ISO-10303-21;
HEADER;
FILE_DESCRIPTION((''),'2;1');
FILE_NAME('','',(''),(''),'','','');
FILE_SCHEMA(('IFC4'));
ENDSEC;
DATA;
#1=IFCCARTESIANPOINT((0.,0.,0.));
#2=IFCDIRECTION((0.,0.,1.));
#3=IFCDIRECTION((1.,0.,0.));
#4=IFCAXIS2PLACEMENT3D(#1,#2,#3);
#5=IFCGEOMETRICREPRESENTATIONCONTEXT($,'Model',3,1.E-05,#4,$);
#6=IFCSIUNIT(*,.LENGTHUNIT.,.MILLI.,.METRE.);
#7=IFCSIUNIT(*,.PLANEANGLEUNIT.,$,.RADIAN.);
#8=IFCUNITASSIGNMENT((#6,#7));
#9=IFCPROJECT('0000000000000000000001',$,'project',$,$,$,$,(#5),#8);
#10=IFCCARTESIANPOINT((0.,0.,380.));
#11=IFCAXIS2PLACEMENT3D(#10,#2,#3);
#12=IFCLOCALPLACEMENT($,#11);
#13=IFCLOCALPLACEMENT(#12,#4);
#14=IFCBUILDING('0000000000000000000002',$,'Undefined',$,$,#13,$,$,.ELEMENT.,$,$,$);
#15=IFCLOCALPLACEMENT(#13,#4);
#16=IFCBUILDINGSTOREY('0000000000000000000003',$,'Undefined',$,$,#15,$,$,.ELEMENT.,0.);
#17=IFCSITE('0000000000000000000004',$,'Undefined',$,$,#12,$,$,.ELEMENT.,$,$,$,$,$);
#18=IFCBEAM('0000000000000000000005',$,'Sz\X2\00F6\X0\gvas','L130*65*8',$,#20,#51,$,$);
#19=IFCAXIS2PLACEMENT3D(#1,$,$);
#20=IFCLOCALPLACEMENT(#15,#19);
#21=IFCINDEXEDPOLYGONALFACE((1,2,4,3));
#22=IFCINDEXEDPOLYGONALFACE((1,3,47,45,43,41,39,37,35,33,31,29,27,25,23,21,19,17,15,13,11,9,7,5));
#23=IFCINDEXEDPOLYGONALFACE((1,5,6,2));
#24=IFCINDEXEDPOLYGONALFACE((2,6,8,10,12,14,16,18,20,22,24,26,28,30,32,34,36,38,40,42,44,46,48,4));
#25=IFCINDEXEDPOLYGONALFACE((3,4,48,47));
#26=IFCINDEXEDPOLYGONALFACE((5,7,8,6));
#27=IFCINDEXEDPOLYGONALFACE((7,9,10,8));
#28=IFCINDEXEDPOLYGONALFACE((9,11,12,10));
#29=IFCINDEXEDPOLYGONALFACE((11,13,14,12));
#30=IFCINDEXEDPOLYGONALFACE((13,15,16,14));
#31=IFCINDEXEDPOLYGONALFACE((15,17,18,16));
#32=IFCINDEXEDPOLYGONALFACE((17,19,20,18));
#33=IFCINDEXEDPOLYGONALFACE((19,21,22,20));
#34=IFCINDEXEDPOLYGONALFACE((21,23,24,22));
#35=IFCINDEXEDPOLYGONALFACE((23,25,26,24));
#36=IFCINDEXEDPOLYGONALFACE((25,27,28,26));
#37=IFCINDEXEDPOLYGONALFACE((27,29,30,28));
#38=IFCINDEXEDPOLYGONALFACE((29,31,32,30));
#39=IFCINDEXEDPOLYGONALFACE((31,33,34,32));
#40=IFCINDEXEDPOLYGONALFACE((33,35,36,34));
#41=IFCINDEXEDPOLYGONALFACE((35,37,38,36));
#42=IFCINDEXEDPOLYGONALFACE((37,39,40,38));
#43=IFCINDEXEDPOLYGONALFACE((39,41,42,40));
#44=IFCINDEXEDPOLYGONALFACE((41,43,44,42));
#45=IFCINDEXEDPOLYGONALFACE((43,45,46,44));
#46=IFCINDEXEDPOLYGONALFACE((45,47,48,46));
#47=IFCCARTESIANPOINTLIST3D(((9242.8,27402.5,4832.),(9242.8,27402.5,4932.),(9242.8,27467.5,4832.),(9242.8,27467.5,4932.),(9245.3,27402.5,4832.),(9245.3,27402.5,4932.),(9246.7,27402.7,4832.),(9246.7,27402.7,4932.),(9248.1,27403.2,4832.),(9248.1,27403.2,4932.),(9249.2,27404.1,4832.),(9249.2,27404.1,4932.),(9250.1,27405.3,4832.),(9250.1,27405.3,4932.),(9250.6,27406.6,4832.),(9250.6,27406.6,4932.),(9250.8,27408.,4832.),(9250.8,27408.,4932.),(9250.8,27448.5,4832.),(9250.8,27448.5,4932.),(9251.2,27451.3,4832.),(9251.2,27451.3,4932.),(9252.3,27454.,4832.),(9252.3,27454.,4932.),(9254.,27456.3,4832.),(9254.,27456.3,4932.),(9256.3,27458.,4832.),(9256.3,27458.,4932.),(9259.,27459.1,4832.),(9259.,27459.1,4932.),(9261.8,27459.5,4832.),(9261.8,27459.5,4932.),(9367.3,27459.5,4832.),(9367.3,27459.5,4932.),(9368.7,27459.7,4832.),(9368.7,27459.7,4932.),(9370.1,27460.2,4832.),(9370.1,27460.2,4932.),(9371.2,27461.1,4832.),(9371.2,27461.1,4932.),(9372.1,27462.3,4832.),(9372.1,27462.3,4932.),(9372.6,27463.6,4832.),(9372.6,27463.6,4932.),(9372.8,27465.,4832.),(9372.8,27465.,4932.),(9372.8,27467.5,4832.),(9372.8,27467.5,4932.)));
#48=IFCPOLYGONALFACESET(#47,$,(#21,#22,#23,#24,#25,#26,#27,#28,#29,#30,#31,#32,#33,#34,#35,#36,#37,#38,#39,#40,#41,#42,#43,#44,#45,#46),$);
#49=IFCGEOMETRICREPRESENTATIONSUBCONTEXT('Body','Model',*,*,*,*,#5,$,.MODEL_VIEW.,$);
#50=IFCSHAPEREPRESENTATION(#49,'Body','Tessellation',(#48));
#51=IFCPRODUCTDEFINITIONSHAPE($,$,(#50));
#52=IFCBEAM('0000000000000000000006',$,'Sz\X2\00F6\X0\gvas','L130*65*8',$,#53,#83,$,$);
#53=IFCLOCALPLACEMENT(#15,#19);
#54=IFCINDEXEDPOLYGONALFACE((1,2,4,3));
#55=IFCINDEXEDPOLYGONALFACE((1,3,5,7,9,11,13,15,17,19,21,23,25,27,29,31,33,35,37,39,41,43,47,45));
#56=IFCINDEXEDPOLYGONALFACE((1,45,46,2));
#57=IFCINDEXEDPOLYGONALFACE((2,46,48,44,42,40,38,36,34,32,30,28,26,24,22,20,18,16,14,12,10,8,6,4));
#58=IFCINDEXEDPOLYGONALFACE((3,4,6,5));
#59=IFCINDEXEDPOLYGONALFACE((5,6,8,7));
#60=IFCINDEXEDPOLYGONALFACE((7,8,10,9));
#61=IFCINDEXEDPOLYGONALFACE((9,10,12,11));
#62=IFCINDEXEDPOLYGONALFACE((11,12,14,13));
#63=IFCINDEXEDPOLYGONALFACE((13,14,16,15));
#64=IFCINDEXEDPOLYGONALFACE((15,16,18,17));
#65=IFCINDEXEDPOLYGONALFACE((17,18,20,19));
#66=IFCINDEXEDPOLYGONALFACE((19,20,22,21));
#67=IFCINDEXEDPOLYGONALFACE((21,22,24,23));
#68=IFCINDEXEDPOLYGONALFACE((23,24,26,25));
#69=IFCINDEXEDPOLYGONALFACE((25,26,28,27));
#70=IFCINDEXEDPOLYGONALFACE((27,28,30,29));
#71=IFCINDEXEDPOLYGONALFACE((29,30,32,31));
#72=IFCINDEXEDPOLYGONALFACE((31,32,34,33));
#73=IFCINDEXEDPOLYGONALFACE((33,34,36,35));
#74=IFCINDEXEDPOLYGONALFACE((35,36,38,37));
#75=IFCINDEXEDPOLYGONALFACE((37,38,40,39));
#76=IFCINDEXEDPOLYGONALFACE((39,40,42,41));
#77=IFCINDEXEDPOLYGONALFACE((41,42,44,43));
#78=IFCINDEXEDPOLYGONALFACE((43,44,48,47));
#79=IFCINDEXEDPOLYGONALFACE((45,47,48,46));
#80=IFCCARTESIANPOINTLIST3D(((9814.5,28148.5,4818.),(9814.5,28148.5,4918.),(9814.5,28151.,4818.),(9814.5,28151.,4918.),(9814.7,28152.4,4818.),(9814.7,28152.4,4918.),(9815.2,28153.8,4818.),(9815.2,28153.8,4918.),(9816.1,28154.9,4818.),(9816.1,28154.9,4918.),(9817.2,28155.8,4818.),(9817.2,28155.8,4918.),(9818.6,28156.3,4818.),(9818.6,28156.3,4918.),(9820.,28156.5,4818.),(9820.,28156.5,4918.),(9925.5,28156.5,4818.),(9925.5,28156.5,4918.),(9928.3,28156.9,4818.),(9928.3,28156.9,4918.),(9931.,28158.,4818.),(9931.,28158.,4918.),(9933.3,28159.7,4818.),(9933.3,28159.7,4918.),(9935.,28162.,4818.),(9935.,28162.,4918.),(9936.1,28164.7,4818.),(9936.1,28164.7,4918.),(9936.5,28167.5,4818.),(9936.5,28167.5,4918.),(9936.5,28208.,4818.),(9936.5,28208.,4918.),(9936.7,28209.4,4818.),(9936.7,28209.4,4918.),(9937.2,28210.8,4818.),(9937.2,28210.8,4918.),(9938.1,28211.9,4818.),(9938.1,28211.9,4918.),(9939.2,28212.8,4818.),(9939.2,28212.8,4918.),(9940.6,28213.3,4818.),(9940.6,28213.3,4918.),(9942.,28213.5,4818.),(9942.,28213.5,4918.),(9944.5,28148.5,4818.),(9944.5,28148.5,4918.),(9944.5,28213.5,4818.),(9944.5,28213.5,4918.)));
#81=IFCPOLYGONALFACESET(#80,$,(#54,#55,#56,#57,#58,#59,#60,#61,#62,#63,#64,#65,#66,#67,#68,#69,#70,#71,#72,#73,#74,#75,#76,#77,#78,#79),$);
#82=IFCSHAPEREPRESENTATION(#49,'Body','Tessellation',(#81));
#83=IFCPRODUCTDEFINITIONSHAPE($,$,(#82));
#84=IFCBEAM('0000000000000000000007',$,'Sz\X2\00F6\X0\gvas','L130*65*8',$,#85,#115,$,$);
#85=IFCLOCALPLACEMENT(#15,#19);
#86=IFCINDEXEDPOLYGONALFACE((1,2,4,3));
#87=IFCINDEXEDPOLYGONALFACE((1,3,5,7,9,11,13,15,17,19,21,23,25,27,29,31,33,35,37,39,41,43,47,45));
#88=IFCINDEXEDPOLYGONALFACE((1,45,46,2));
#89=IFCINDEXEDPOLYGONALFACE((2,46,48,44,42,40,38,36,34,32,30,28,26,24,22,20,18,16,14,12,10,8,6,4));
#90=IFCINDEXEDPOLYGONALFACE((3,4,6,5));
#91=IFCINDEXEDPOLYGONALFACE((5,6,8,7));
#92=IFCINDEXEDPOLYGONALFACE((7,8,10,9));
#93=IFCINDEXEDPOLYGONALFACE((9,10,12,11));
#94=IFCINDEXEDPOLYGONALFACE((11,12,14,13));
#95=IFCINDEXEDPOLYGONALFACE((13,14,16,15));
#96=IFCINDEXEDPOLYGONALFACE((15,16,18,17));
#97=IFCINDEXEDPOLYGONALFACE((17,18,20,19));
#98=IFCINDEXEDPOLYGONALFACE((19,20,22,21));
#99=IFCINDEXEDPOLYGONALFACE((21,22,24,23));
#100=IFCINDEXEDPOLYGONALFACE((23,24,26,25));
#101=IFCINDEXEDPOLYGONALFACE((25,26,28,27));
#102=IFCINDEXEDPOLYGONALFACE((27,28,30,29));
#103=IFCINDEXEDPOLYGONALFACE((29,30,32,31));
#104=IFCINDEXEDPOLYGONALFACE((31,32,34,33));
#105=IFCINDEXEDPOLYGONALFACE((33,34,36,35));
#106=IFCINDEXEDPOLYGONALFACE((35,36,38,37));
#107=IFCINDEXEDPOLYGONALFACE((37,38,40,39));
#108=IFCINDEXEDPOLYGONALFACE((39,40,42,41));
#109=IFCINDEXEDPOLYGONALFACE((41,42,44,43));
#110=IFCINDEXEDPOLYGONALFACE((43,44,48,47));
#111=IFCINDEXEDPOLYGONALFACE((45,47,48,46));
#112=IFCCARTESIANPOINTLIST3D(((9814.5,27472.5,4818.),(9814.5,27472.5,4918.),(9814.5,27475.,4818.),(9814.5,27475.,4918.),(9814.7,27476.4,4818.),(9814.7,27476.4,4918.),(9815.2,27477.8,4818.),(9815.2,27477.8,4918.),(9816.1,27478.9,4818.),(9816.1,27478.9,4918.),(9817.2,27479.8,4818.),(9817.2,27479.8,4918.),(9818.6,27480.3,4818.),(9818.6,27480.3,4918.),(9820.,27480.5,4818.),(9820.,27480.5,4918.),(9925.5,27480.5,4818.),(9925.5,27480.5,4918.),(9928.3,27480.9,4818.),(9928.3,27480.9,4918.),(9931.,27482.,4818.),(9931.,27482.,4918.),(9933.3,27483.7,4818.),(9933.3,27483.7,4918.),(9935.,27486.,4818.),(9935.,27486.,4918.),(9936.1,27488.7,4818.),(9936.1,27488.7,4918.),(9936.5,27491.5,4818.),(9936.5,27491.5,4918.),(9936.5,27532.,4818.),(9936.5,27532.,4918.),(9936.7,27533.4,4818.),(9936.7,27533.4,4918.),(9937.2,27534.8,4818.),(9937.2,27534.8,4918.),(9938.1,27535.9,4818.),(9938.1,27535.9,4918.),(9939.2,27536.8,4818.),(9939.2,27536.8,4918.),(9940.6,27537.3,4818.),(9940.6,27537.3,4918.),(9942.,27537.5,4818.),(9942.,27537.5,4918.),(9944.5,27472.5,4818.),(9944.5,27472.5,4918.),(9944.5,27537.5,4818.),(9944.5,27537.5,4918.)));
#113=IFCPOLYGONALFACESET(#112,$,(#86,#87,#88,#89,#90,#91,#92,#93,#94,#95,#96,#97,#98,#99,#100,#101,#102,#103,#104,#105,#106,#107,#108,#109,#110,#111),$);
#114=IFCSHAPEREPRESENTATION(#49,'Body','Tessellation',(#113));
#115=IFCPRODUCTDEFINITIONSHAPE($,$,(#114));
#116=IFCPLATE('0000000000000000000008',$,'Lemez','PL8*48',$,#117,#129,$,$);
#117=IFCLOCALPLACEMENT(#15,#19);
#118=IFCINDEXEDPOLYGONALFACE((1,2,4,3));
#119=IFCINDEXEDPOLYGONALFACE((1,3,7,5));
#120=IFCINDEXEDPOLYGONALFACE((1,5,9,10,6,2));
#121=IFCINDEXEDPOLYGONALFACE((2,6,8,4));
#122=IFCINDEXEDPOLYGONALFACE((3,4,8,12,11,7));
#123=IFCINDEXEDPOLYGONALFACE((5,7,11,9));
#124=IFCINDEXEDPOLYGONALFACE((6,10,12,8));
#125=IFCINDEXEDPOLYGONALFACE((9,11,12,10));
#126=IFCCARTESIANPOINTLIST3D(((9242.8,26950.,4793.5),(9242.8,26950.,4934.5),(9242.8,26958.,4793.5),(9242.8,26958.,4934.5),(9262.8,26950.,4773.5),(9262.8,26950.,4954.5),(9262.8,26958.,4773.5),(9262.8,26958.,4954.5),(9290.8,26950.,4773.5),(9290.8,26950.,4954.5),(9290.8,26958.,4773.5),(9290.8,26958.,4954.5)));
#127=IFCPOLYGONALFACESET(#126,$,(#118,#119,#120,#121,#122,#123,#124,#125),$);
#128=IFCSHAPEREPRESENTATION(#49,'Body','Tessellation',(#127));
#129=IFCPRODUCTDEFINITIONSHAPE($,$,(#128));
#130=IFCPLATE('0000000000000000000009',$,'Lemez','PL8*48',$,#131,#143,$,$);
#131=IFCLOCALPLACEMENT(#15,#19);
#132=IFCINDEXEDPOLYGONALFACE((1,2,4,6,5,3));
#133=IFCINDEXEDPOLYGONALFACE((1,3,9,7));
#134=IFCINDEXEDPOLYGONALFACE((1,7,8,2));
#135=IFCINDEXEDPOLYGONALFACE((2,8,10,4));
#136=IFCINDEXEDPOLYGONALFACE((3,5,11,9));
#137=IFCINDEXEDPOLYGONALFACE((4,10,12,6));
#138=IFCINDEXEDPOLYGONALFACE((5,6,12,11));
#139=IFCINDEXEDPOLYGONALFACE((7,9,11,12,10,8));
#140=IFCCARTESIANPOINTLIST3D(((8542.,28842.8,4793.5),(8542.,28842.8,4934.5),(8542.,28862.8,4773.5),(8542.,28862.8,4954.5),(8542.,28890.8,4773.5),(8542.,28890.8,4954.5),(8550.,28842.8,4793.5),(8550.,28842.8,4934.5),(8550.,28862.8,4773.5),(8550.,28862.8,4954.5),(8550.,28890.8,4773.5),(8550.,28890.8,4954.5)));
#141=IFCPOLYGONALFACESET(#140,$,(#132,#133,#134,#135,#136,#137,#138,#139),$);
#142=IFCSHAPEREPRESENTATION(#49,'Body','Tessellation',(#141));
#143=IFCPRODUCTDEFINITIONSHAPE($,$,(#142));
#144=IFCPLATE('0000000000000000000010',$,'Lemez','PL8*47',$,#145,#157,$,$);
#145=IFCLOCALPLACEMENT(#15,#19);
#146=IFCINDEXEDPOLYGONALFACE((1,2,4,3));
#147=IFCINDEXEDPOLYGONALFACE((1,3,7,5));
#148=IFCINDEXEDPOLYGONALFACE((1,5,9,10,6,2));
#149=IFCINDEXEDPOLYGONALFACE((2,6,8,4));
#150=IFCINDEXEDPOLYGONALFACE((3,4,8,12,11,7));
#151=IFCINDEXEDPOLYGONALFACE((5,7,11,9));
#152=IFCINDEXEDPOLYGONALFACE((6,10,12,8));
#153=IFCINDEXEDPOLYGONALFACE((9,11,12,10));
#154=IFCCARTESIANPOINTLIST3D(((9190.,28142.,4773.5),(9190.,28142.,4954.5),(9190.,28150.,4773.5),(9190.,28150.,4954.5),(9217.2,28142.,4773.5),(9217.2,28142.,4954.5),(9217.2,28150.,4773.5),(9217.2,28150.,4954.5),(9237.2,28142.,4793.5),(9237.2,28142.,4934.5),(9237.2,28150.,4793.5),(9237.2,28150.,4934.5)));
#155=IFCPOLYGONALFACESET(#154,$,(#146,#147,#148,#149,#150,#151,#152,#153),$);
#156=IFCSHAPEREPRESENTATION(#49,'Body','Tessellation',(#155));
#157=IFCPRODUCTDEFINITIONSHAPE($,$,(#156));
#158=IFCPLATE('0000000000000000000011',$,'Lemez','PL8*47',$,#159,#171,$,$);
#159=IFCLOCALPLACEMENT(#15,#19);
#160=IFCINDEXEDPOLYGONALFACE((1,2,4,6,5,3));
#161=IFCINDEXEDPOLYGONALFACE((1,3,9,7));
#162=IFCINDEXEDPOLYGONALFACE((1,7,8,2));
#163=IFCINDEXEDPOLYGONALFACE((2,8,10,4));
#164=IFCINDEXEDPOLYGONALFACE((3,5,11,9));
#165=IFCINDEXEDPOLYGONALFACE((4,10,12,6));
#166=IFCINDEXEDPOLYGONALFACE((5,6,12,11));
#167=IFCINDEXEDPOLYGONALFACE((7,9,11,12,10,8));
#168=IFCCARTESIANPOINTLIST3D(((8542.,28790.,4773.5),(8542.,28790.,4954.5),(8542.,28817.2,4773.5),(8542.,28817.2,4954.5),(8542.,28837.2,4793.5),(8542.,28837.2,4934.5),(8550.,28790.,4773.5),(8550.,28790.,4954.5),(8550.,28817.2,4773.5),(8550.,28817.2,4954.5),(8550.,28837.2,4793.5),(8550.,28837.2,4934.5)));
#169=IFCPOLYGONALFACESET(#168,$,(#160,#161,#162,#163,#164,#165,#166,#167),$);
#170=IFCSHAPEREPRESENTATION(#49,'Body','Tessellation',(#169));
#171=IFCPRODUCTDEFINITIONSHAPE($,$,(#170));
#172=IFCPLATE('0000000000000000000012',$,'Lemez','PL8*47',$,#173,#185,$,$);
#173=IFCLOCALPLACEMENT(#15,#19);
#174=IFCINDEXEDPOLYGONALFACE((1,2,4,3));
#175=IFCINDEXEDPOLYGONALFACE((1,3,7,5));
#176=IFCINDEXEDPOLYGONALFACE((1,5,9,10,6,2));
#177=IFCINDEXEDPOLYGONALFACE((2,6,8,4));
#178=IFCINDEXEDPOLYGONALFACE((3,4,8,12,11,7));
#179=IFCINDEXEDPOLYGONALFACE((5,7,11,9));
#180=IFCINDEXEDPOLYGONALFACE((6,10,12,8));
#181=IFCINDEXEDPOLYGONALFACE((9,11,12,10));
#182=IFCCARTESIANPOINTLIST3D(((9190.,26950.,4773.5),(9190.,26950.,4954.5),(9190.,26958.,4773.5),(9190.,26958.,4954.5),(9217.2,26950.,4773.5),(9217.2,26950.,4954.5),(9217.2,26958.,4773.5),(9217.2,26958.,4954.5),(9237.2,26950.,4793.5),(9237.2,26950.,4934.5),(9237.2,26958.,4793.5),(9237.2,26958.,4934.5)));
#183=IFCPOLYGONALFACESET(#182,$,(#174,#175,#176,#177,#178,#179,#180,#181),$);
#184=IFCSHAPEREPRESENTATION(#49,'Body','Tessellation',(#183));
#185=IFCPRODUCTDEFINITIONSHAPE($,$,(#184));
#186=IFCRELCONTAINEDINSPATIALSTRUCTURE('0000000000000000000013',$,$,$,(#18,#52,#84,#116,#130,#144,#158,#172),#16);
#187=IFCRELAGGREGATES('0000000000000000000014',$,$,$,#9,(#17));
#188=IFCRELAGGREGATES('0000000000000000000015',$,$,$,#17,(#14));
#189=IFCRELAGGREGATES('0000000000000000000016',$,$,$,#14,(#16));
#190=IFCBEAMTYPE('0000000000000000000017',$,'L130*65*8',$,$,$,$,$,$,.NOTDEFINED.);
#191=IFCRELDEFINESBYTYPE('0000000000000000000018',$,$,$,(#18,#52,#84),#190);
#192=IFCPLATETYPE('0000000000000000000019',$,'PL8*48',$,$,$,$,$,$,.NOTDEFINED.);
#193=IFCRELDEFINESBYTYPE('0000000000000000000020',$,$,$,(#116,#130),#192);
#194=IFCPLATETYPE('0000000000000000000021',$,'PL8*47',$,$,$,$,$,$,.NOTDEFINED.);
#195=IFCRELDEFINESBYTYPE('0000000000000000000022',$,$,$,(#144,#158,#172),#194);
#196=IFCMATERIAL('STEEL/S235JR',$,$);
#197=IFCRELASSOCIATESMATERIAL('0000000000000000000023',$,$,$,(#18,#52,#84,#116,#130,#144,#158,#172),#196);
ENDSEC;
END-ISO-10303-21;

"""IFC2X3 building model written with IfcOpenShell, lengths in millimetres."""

from ifc_helpers import new_model, si_unit, frame, origin_with_axes, origin_2d_with_axis, place, context, subcontext, project, spatial, polyline, l_section, outline, extrude, material, type_object, element, save


model = new_model("IFC2X3")

# Units and contexts
model_context = context("Model", 3, precision=1e-05, world=origin_with_axes())
body_context = subcontext(model_context, "Body", "Model", "MODEL_VIEW")
ifc_project = project(units=[si_unit("LENGTHUNIT", "METRE", prefix="MILLI"), si_unit("PLANEANGLEUNIT", "RADIAN")], contexts=[model_context])

# Site, building, storey
site_placement = place(None, frame((0.0, 0.0, 380.0), z_axis=(0.0, 0.0, 1.0), x_axis=(1.0, 0.0, 0.0)))
site = spatial("IfcSite", under=ifc_project, at=site_placement, Name="Undefined", CompositionType="ELEMENT")
building_placement = place(site_placement, origin_with_axes())
building = spatial("IfcBuilding", under=site, at=building_placement, Name="Undefined", CompositionType="ELEMENT")
storey_placement = place(building_placement, origin_with_axes())
storey = spatial("IfcBuildingStorey", under=building, at=storey_placement, Name="Undefined", CompositionType="ELEMENT", Elevation=0.0)

# Shared definitions
ifc_material = material(Name="STEEL/S235JR")

# Beams
beam_type_1 = type_object("IfcBeamType", Name="L130*65*8", PredefinedType="NOTDEFINED")
beam_1_placement = place(storey_placement, frame((9307.8, 27435.0, 4932.0), z_axis=(1.0, 0.0, 0.0), x_axis=(0.0, 0.0, -1.0)))
element("IfcBeam", 1, at=beam_1_placement, inside=storey, type_object=beam_type_1, material=ifc_material, Name="Szögvas", Description="L130*65*8", context=body_context, shape_type="SweptSolid", body=[
    extrude(l_section(Depth=130.0, Width=65.0, Thickness=8.0, FilletRadius=11.0, EdgeRadius=5.5, at=origin_2d_with_axis()), frame((100.0, 0.0, 0.0), z_axis=(-1.0, 0.0, 0.0), x_axis=(0.0, -1.0, 0.0)), (0.0, 0.0, 1.0), 100.0),
])
beam_2_placement = place(storey_placement, frame((9879.5, 28181.0, 4918.0), z_axis=(-1.0, 0.0, 0.0), x_axis=(0.0, 0.0, -1.0)))
element("IfcBeam", 2, at=beam_2_placement, inside=storey, type_object=beam_type_1, material=ifc_material, Name="Szögvas", Description="L130*65*8", context=body_context, shape_type="SweptSolid", body=[
    extrude(l_section(Depth=130.0, Width=65.0, Thickness=8.0, FilletRadius=11.0, EdgeRadius=5.5, at=origin_2d_with_axis()), frame((100.0, 0.0, 0.0), z_axis=(-1.0, 0.0, 0.0), x_axis=(0.0, -1.0, 0.0)), (0.0, 0.0, 1.0), 100.0),
])
beam_3_placement = place(storey_placement, frame((9879.5, 27505.0, 4918.0), z_axis=(-1.0, 0.0, 0.0), x_axis=(0.0, 0.0, -1.0)))
element("IfcBeam", 3, at=beam_3_placement, inside=storey, type_object=beam_type_1, material=ifc_material, Name="Szögvas", Description="L130*65*8", context=body_context, shape_type="SweptSolid", body=[
    extrude(l_section(Depth=130.0, Width=65.0, Thickness=8.0, FilletRadius=11.0, EdgeRadius=5.5, at=origin_2d_with_axis()), frame((100.0, 0.0, 0.0), z_axis=(-1.0, 0.0, 0.0), x_axis=(0.0, -1.0, 0.0)), (0.0, 0.0, 1.0), 100.0),
])

# Plates
plate_type_1 = type_object("IfcPlateType", Name="PL8*48", PredefinedType="NOTDEFINED")
for number, where, z_axis, x_axis, name in (
    (4, (9242.8, 26954.0, 4773.5), (0.0, -1.0, 0.0), (1.0, 0.0, 0.0), "Lemez"),
    (5, (8546.0, 28842.8, 4773.5), (1.0, 0.0, 0.0), (0.0, 1.0, 0.0), "Lemez"),
):
    element("IfcPlate", number, at=place(storey_placement, frame(where, z_axis=z_axis, x_axis=x_axis)), inside=storey, type_object=plate_type_1, material=ifc_material, Name=name, Description="PL8*48", context=body_context, shape_type="SweptSolid", body=[
        extrude(outline(polyline([(0.0, 20.0), (20.0, 0.0), (48.0, 0.0), (48.0, 181.0), (20.0, 181.0), (0.0, 161.0), (0.0, 20.0)])), frame((0.0, 0.0, -4.0), z_axis=(0.0, 0.0, 1.0), x_axis=(1.0, 0.0, 0.0)), (0.0, 0.0, 1.0), 8.0),
    ])
plate_type_2 = type_object("IfcPlateType", Name="PL8*47", PredefinedType="NOTDEFINED")
for number, where, z_axis, x_axis, name in (
    (6, (9237.2, 28146.0, 4773.5), (0.0, 1.0, 0.0), (-1.0, 0.0, 0.0), "Lemez"),
    (7, (8546.0, 28837.2, 4773.5), (-1.0, 0.0, 0.0), (0.0, -1.0, 0.0), "Lemez"),
    (8, (9237.2, 26954.0, 4773.5), (0.0, 1.0, 0.0), (-1.0, 0.0, 0.0), "Lemez"),
):
    element("IfcPlate", number, at=place(storey_placement, frame(where, z_axis=z_axis, x_axis=x_axis)), inside=storey, type_object=plate_type_2, material=ifc_material, Name=name, Description="PL8*47", context=body_context, shape_type="SweptSolid", body=[
        extrude(outline(polyline([(0.0, 20.0), (20.0, 0.0), (47.2, 0.0), (47.2, 181.0), (20.0, 181.0), (0.0, 161.0), (0.0, 20.0)])), frame((0.0, 0.0, -4.0), z_axis=(0.0, 0.0, 1.0), x_axis=(1.0, 0.0, 0.0)), (0.0, 0.0, 1.0), 8.0),
    ])

save(model, "model.ifc")
